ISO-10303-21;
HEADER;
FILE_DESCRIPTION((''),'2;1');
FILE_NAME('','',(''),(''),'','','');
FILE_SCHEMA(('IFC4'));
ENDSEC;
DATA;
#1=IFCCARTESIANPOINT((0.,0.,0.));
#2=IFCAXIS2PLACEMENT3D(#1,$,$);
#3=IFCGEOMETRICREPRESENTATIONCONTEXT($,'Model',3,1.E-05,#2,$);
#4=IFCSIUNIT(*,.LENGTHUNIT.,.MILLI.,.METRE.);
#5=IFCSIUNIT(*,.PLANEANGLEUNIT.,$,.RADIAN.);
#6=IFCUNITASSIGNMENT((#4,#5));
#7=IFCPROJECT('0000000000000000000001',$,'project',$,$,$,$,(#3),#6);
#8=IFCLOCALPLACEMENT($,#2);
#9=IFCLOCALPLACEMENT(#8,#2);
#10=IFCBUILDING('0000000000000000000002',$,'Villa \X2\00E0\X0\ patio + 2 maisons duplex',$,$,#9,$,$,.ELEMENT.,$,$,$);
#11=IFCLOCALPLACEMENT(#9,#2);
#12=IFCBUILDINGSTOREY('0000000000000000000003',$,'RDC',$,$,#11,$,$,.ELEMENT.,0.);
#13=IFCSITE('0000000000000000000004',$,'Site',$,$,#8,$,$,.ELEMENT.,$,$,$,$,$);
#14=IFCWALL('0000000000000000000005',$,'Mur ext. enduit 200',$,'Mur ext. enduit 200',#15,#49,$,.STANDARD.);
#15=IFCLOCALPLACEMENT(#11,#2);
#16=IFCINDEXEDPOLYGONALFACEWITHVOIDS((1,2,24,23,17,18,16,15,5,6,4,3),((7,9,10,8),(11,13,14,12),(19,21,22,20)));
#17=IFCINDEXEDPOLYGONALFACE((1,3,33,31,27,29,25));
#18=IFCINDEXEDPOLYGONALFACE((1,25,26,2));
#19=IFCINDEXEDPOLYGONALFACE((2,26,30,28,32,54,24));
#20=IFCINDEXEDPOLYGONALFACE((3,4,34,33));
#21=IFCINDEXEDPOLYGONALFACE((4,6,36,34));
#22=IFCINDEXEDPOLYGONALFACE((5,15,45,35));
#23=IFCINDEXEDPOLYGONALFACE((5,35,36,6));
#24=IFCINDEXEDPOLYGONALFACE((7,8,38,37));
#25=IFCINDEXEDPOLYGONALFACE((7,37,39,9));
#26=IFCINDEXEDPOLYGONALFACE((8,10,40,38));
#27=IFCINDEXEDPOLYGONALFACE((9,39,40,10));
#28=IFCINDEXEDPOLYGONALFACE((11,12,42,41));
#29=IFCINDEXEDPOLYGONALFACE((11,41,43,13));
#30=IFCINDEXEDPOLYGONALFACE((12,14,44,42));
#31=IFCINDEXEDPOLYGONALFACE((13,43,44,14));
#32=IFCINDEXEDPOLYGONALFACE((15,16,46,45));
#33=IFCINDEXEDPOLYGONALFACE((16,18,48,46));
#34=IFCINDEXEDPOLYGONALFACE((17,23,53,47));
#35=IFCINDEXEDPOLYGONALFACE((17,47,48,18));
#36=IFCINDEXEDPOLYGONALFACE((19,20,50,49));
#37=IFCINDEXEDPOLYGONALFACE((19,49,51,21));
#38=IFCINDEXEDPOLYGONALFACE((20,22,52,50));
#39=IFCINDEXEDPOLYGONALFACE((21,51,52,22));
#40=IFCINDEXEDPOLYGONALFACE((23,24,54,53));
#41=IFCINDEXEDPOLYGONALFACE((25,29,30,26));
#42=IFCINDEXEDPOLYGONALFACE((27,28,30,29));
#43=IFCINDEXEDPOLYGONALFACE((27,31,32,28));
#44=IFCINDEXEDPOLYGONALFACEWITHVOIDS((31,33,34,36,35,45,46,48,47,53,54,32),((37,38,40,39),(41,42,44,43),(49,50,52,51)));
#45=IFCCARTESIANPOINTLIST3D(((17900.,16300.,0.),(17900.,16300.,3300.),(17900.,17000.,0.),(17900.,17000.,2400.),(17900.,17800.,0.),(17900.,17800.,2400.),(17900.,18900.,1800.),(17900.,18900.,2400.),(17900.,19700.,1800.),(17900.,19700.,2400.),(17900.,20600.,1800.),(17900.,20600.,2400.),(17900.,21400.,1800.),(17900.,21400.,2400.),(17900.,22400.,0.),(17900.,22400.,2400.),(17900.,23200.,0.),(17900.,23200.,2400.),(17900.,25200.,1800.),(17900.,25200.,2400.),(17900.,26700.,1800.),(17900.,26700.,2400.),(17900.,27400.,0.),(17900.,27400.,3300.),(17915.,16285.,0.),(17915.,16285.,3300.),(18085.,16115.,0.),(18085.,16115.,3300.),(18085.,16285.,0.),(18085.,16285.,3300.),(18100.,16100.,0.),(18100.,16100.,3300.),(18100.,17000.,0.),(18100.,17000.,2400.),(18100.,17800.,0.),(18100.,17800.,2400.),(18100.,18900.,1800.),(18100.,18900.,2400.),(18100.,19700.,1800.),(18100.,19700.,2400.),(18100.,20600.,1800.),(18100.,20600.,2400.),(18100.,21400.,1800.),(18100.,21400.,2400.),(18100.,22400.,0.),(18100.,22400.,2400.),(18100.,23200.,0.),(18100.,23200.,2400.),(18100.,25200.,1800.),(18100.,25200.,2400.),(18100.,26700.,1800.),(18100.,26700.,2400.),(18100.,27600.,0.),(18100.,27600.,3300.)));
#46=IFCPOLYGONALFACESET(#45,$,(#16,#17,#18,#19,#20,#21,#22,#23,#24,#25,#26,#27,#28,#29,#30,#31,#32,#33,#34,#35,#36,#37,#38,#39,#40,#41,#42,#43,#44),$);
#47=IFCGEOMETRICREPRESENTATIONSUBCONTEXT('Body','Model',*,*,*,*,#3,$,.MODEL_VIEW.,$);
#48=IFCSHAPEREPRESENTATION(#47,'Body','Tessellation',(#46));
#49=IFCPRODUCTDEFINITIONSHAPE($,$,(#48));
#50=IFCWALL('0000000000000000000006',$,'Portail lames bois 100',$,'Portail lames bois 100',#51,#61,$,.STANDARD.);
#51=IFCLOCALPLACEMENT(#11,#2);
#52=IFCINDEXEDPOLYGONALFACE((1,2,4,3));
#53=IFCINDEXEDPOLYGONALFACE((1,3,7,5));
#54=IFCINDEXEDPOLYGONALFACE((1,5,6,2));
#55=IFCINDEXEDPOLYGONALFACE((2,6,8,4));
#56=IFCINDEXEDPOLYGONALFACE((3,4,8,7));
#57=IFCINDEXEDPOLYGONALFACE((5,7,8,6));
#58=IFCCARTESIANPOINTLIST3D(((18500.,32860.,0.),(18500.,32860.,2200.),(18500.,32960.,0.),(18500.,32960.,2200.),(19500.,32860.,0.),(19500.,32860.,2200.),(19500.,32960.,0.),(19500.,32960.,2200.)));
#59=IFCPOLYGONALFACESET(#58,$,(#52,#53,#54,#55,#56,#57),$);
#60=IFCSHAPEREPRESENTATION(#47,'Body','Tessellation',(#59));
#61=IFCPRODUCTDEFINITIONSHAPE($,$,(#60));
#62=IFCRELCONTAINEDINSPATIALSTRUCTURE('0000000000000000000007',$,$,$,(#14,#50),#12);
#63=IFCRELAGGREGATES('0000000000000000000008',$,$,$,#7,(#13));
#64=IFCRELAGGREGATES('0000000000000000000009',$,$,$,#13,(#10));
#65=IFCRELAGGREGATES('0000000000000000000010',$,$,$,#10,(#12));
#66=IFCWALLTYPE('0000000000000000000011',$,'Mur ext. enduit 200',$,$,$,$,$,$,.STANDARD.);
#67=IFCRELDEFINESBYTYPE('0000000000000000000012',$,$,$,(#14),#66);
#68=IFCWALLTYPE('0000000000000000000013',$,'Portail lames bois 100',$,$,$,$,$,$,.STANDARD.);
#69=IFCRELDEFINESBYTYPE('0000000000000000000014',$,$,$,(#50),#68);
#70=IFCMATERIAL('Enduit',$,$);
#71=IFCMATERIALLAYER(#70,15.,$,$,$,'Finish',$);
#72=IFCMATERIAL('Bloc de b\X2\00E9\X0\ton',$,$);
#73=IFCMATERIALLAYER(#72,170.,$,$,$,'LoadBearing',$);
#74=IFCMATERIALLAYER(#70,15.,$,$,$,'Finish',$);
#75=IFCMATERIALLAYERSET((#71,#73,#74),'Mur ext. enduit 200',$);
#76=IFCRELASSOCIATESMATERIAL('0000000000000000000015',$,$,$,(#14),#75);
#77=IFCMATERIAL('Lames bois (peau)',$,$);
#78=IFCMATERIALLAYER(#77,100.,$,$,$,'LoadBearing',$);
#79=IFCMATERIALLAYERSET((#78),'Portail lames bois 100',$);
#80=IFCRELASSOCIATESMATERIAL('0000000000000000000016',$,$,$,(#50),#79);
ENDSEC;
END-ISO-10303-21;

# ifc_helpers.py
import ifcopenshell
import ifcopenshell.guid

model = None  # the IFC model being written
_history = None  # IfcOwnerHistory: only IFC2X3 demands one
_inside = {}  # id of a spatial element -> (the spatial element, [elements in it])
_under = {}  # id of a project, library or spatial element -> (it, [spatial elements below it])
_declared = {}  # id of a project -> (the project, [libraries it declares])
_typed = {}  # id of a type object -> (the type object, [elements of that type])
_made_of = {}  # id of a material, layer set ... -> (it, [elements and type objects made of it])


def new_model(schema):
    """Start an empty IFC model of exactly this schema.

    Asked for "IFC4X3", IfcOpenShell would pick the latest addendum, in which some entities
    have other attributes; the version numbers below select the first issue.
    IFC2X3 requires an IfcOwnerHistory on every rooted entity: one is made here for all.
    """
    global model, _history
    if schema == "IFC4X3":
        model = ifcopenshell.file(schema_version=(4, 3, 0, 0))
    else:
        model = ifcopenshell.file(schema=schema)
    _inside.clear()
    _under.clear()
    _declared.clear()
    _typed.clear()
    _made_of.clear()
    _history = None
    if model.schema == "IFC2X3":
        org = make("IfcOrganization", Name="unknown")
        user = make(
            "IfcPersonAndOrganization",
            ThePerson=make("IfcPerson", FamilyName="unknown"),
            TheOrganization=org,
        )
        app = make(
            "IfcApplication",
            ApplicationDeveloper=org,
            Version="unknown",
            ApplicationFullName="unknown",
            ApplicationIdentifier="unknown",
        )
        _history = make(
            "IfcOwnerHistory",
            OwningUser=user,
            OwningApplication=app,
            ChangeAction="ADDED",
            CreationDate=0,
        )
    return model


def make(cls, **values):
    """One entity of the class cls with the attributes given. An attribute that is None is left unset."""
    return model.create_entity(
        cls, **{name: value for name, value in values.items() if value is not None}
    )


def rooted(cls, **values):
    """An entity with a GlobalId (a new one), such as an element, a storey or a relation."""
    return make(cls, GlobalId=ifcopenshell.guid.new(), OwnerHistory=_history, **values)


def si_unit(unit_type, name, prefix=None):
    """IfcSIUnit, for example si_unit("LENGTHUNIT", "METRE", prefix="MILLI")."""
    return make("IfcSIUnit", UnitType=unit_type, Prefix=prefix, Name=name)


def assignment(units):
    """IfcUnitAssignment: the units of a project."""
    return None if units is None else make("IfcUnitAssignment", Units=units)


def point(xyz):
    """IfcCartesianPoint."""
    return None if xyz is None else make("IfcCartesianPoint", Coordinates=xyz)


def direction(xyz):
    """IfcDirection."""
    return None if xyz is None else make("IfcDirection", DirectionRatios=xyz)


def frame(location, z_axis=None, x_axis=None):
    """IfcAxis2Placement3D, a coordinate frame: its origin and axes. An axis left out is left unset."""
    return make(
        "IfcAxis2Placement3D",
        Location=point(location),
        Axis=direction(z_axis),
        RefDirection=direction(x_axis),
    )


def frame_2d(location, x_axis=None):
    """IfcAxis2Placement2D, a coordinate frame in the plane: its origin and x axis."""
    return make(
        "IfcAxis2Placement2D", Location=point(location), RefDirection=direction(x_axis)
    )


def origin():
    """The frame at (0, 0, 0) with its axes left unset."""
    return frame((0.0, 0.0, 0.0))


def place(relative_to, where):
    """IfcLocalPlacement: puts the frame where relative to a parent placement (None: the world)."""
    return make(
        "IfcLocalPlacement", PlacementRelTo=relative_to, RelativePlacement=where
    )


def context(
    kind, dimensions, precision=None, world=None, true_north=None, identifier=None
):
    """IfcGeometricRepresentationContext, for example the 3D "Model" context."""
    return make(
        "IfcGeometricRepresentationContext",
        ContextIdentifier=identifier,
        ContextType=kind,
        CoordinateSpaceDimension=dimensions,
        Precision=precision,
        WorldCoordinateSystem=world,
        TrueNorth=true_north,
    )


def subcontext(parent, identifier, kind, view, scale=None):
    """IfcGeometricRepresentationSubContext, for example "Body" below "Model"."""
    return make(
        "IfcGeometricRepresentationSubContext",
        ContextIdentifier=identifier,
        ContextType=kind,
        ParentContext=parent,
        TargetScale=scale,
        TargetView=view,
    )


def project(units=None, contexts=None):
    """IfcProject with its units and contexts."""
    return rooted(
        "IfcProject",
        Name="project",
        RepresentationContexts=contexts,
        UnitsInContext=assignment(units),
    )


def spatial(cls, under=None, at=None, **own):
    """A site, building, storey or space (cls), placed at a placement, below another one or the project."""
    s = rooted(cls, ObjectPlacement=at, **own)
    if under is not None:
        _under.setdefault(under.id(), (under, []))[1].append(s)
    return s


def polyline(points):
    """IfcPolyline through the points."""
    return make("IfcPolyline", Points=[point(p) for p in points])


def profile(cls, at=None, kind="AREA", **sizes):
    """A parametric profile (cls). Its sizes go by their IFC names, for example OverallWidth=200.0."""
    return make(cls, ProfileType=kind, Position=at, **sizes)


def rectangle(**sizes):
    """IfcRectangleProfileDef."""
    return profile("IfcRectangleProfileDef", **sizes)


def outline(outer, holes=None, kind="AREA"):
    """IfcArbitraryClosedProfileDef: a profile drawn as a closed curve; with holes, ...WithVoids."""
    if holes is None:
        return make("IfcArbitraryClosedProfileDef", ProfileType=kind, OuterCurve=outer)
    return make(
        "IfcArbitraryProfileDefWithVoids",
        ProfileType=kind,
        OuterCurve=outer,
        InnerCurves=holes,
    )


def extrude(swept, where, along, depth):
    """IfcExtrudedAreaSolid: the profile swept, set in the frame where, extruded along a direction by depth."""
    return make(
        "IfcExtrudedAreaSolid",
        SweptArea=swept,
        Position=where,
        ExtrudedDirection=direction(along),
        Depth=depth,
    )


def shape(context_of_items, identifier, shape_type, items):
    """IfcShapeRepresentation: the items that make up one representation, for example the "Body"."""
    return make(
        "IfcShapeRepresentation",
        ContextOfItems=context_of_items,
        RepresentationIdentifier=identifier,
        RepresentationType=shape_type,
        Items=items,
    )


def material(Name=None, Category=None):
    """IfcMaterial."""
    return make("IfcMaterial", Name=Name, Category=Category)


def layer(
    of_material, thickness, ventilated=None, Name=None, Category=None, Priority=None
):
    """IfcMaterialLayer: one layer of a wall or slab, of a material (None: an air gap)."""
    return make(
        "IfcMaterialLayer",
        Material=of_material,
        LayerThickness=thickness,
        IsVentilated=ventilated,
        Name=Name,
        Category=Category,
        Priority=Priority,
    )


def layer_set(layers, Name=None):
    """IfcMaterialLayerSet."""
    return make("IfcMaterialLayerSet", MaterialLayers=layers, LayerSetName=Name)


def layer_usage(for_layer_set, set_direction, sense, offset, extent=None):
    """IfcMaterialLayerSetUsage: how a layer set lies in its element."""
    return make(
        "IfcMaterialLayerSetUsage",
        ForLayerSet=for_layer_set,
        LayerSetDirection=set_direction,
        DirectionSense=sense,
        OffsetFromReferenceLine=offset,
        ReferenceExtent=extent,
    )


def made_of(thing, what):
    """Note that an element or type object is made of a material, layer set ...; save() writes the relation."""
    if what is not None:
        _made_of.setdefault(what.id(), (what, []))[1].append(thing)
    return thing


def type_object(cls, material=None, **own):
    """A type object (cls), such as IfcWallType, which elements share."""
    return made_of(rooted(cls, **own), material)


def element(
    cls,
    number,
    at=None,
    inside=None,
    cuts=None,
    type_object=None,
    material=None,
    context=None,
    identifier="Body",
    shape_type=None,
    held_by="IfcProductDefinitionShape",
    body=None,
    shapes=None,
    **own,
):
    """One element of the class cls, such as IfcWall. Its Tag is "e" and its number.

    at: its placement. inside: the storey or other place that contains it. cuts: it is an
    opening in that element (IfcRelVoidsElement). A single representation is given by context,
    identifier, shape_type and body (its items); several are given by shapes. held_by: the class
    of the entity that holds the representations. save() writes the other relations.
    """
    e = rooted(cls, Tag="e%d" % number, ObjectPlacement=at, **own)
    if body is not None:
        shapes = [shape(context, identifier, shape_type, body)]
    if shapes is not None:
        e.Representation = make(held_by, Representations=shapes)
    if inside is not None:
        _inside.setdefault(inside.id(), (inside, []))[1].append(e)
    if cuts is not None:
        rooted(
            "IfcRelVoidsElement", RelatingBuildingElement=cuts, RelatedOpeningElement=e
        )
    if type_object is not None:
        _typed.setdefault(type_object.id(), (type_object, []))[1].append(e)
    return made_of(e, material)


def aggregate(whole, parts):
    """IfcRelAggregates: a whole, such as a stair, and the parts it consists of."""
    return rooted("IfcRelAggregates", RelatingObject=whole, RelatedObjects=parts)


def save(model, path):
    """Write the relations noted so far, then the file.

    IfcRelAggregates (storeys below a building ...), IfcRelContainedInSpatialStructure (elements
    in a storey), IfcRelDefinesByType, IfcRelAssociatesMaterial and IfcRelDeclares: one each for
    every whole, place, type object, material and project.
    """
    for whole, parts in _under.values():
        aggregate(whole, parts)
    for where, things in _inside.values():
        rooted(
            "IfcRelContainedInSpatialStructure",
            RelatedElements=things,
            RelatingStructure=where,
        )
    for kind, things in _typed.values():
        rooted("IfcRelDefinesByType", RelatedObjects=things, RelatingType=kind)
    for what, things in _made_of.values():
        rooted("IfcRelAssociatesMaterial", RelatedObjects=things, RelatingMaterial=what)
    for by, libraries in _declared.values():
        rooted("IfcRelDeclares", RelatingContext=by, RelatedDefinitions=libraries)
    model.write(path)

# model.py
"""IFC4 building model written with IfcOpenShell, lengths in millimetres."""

from ifc_helpers import new_model, si_unit, frame, frame_2d, origin, place, context, subcontext, project, spatial, polyline, rectangle, outline, extrude, material, layer, layer_set, layer_usage, type_object, element, save


model = new_model("IFC4")

# Units and contexts
model_context = context("Model", 3, precision=1e-05, world=origin())
body_context = subcontext(model_context, "Body", "Model", "MODEL_VIEW")
ifc_project = project(units=[si_unit("LENGTHUNIT", "METRE", prefix="MILLI"), si_unit("PLANEANGLEUNIT", "RADIAN")], contexts=[model_context])

# Site, building, storey
site_placement = place(None, origin())
site = spatial("IfcSite", under=ifc_project, at=site_placement, Name="Site", CompositionType="ELEMENT")
building_placement = place(site_placement, origin())
building = spatial("IfcBuilding", under=site, at=building_placement, Name="Villa à patio + 2 maisons duplex", CompositionType="ELEMENT")
storey_placement = place(building_placement, origin())
storey = spatial("IfcBuildingStorey", under=building, at=storey_placement, Name="RDC", CompositionType="ELEMENT", Elevation=0.0)

# Shared definitions
ifc_material_1 = material(Name="Enduit")
ifc_material_2 = material(Name="Bloc de béton")

# Shared definitions
ifc_layer_1 = layer(ifc_material_1, 15.0, Category="Finish")
ifc_layer_2 = layer(ifc_material_2, 170.0, Category="LoadBearing")
ifc_layer_3 = layer(ifc_material_1, 15.0, Category="Finish")
ifc_layer_set_1 = layer_set([ifc_layer_1, ifc_layer_2, ifc_layer_3], Name="Mur ext. enduit 200")
ifc_layer_usage_1 = layer_usage(ifc_layer_set_1, "AXIS2", "NEGATIVE", 100.0)
wall_type_1 = type_object("IfcWallType", Name="Mur ext. enduit 200", PredefinedType="STANDARD")

# Wall, openings
wall_1_placement = place(storey_placement, frame((18000.0, 27500.0, 0.0), z_axis=(0.0, 0.0, 1.0), x_axis=(0.0, -1.0, 0.0)))
wall_1 = element("IfcWall", 1, at=wall_1_placement, inside=storey, type_object=wall_type_1, material=ifc_layer_usage_1, Name="Mur ext. enduit 200", ObjectType="Mur ext. enduit 200", PredefinedType="STANDARD", context=body_context, shape_type="SweptSolid", body=[
    extrude(outline(polyline([(100.0, -100.0), (0.0, 0.0), (-100.0, 100.0), (11400.0, 100.0), (11385.0, 85.0), (11215.0, 85.0), (11215.0, -85.0), (11200.0, -100.0), (100.0, -100.0)])), origin(), (0.0, 0.0, 1.0), 3300.0),
])
opening_1_placement = place(wall_1_placement, frame((800.0, 0.0, 1800.0), z_axis=(0.0, 0.0, 1.0), x_axis=(1.0, 0.0, 0.0)))
element("IfcOpeningElement", 2, at=opening_1_placement, cuts=wall_1, PredefinedType="OPENING", context=body_context, shape_type="SweptSolid", body=[
    extrude(rectangle(XDim=1500.0, YDim=220.0, at=frame_2d((750.0, 0.0))), origin(), (0.0, 0.0, 1.0), 600.0),
])
opening_2_placement = place(wall_1_placement, frame((4300.0, 0.0, 0.0), z_axis=(0.0, 0.0, 1.0), x_axis=(1.0, 0.0, 0.0)))
element("IfcOpeningElement", 3, at=opening_2_placement, cuts=wall_1, PredefinedType="OPENING", context=body_context, shape_type="SweptSolid", body=[
    extrude(rectangle(XDim=800.0, YDim=220.0, at=frame_2d((400.0, 0.0))), origin(), (0.0, 0.0, 1.0), 2400.0),
])
opening_3_placement = place(wall_1_placement, frame((6100.0, 0.0, 1800.0), z_axis=(0.0, 0.0, 1.0), x_axis=(1.0, 0.0, 0.0)))
element("IfcOpeningElement", 4, at=opening_3_placement, cuts=wall_1, PredefinedType="OPENING", context=body_context, shape_type="SweptSolid", body=[
    extrude(rectangle(XDim=800.0, YDim=220.0, at=frame_2d((400.0, 0.0))), origin(), (0.0, 0.0, 1.0), 600.0),
])
opening_4_placement = place(wall_1_placement, frame((7800.0, 0.0, 1800.0), z_axis=(0.0, 0.0, 1.0), x_axis=(1.0, 0.0, 0.0)))
element("IfcOpeningElement", 5, at=opening_4_placement, cuts=wall_1, PredefinedType="OPENING", context=body_context, shape_type="SweptSolid", body=[
    extrude(rectangle(XDim=800.0, YDim=220.0, at=frame_2d((400.0, 0.0))), origin(), (0.0, 0.0, 1.0), 600.0),
])
opening_5_placement = place(wall_1_placement, frame((9700.0, 0.0, 0.0), z_axis=(0.0, 0.0, 1.0), x_axis=(1.0, 0.0, 0.0)))
element("IfcOpeningElement", 6, at=opening_5_placement, cuts=wall_1, PredefinedType="OPENING", context=body_context, shape_type="SweptSolid", body=[
    extrude(rectangle(XDim=800.0, YDim=220.0, at=frame_2d((400.0, 0.0))), origin(), (0.0, 0.0, 1.0), 2400.0),
])

# Wall
ifc_material_3 = material(Name="Lames bois (peau)")
ifc_layer_4 = layer(ifc_material_3, 100.0, Category="LoadBearing")
ifc_layer_set_2 = layer_set([ifc_layer_4], Name="Portail lames bois 100")
ifc_layer_usage_2 = layer_usage(ifc_layer_set_2, "AXIS2", "NEGATIVE", 50.0)
wall_type_2 = type_object("IfcWallType", Name="Portail lames bois 100", PredefinedType="STANDARD")
wall_2_placement = place(storey_placement, frame((18500.0, 32910.0, 0.0), z_axis=(0.0, 0.0, 1.0), x_axis=(1.0, 0.0, 0.0)))
element("IfcWall", 7, at=wall_2_placement, inside=storey, type_object=wall_type_2, material=ifc_layer_usage_2, Name="Portail lames bois 100", ObjectType="Portail lames bois 100", PredefinedType="STANDARD", context=body_context, shape_type="SweptSolid", body=[
    extrude(outline(polyline([(0.0, -50.0), (0.0, 50.0), (1000.0, 50.0), (1000.0, -50.0), (0.0, -50.0)])), origin(), (0.0, 0.0, 1.0), 2200.0),
])

save(model, "model.ifc")
